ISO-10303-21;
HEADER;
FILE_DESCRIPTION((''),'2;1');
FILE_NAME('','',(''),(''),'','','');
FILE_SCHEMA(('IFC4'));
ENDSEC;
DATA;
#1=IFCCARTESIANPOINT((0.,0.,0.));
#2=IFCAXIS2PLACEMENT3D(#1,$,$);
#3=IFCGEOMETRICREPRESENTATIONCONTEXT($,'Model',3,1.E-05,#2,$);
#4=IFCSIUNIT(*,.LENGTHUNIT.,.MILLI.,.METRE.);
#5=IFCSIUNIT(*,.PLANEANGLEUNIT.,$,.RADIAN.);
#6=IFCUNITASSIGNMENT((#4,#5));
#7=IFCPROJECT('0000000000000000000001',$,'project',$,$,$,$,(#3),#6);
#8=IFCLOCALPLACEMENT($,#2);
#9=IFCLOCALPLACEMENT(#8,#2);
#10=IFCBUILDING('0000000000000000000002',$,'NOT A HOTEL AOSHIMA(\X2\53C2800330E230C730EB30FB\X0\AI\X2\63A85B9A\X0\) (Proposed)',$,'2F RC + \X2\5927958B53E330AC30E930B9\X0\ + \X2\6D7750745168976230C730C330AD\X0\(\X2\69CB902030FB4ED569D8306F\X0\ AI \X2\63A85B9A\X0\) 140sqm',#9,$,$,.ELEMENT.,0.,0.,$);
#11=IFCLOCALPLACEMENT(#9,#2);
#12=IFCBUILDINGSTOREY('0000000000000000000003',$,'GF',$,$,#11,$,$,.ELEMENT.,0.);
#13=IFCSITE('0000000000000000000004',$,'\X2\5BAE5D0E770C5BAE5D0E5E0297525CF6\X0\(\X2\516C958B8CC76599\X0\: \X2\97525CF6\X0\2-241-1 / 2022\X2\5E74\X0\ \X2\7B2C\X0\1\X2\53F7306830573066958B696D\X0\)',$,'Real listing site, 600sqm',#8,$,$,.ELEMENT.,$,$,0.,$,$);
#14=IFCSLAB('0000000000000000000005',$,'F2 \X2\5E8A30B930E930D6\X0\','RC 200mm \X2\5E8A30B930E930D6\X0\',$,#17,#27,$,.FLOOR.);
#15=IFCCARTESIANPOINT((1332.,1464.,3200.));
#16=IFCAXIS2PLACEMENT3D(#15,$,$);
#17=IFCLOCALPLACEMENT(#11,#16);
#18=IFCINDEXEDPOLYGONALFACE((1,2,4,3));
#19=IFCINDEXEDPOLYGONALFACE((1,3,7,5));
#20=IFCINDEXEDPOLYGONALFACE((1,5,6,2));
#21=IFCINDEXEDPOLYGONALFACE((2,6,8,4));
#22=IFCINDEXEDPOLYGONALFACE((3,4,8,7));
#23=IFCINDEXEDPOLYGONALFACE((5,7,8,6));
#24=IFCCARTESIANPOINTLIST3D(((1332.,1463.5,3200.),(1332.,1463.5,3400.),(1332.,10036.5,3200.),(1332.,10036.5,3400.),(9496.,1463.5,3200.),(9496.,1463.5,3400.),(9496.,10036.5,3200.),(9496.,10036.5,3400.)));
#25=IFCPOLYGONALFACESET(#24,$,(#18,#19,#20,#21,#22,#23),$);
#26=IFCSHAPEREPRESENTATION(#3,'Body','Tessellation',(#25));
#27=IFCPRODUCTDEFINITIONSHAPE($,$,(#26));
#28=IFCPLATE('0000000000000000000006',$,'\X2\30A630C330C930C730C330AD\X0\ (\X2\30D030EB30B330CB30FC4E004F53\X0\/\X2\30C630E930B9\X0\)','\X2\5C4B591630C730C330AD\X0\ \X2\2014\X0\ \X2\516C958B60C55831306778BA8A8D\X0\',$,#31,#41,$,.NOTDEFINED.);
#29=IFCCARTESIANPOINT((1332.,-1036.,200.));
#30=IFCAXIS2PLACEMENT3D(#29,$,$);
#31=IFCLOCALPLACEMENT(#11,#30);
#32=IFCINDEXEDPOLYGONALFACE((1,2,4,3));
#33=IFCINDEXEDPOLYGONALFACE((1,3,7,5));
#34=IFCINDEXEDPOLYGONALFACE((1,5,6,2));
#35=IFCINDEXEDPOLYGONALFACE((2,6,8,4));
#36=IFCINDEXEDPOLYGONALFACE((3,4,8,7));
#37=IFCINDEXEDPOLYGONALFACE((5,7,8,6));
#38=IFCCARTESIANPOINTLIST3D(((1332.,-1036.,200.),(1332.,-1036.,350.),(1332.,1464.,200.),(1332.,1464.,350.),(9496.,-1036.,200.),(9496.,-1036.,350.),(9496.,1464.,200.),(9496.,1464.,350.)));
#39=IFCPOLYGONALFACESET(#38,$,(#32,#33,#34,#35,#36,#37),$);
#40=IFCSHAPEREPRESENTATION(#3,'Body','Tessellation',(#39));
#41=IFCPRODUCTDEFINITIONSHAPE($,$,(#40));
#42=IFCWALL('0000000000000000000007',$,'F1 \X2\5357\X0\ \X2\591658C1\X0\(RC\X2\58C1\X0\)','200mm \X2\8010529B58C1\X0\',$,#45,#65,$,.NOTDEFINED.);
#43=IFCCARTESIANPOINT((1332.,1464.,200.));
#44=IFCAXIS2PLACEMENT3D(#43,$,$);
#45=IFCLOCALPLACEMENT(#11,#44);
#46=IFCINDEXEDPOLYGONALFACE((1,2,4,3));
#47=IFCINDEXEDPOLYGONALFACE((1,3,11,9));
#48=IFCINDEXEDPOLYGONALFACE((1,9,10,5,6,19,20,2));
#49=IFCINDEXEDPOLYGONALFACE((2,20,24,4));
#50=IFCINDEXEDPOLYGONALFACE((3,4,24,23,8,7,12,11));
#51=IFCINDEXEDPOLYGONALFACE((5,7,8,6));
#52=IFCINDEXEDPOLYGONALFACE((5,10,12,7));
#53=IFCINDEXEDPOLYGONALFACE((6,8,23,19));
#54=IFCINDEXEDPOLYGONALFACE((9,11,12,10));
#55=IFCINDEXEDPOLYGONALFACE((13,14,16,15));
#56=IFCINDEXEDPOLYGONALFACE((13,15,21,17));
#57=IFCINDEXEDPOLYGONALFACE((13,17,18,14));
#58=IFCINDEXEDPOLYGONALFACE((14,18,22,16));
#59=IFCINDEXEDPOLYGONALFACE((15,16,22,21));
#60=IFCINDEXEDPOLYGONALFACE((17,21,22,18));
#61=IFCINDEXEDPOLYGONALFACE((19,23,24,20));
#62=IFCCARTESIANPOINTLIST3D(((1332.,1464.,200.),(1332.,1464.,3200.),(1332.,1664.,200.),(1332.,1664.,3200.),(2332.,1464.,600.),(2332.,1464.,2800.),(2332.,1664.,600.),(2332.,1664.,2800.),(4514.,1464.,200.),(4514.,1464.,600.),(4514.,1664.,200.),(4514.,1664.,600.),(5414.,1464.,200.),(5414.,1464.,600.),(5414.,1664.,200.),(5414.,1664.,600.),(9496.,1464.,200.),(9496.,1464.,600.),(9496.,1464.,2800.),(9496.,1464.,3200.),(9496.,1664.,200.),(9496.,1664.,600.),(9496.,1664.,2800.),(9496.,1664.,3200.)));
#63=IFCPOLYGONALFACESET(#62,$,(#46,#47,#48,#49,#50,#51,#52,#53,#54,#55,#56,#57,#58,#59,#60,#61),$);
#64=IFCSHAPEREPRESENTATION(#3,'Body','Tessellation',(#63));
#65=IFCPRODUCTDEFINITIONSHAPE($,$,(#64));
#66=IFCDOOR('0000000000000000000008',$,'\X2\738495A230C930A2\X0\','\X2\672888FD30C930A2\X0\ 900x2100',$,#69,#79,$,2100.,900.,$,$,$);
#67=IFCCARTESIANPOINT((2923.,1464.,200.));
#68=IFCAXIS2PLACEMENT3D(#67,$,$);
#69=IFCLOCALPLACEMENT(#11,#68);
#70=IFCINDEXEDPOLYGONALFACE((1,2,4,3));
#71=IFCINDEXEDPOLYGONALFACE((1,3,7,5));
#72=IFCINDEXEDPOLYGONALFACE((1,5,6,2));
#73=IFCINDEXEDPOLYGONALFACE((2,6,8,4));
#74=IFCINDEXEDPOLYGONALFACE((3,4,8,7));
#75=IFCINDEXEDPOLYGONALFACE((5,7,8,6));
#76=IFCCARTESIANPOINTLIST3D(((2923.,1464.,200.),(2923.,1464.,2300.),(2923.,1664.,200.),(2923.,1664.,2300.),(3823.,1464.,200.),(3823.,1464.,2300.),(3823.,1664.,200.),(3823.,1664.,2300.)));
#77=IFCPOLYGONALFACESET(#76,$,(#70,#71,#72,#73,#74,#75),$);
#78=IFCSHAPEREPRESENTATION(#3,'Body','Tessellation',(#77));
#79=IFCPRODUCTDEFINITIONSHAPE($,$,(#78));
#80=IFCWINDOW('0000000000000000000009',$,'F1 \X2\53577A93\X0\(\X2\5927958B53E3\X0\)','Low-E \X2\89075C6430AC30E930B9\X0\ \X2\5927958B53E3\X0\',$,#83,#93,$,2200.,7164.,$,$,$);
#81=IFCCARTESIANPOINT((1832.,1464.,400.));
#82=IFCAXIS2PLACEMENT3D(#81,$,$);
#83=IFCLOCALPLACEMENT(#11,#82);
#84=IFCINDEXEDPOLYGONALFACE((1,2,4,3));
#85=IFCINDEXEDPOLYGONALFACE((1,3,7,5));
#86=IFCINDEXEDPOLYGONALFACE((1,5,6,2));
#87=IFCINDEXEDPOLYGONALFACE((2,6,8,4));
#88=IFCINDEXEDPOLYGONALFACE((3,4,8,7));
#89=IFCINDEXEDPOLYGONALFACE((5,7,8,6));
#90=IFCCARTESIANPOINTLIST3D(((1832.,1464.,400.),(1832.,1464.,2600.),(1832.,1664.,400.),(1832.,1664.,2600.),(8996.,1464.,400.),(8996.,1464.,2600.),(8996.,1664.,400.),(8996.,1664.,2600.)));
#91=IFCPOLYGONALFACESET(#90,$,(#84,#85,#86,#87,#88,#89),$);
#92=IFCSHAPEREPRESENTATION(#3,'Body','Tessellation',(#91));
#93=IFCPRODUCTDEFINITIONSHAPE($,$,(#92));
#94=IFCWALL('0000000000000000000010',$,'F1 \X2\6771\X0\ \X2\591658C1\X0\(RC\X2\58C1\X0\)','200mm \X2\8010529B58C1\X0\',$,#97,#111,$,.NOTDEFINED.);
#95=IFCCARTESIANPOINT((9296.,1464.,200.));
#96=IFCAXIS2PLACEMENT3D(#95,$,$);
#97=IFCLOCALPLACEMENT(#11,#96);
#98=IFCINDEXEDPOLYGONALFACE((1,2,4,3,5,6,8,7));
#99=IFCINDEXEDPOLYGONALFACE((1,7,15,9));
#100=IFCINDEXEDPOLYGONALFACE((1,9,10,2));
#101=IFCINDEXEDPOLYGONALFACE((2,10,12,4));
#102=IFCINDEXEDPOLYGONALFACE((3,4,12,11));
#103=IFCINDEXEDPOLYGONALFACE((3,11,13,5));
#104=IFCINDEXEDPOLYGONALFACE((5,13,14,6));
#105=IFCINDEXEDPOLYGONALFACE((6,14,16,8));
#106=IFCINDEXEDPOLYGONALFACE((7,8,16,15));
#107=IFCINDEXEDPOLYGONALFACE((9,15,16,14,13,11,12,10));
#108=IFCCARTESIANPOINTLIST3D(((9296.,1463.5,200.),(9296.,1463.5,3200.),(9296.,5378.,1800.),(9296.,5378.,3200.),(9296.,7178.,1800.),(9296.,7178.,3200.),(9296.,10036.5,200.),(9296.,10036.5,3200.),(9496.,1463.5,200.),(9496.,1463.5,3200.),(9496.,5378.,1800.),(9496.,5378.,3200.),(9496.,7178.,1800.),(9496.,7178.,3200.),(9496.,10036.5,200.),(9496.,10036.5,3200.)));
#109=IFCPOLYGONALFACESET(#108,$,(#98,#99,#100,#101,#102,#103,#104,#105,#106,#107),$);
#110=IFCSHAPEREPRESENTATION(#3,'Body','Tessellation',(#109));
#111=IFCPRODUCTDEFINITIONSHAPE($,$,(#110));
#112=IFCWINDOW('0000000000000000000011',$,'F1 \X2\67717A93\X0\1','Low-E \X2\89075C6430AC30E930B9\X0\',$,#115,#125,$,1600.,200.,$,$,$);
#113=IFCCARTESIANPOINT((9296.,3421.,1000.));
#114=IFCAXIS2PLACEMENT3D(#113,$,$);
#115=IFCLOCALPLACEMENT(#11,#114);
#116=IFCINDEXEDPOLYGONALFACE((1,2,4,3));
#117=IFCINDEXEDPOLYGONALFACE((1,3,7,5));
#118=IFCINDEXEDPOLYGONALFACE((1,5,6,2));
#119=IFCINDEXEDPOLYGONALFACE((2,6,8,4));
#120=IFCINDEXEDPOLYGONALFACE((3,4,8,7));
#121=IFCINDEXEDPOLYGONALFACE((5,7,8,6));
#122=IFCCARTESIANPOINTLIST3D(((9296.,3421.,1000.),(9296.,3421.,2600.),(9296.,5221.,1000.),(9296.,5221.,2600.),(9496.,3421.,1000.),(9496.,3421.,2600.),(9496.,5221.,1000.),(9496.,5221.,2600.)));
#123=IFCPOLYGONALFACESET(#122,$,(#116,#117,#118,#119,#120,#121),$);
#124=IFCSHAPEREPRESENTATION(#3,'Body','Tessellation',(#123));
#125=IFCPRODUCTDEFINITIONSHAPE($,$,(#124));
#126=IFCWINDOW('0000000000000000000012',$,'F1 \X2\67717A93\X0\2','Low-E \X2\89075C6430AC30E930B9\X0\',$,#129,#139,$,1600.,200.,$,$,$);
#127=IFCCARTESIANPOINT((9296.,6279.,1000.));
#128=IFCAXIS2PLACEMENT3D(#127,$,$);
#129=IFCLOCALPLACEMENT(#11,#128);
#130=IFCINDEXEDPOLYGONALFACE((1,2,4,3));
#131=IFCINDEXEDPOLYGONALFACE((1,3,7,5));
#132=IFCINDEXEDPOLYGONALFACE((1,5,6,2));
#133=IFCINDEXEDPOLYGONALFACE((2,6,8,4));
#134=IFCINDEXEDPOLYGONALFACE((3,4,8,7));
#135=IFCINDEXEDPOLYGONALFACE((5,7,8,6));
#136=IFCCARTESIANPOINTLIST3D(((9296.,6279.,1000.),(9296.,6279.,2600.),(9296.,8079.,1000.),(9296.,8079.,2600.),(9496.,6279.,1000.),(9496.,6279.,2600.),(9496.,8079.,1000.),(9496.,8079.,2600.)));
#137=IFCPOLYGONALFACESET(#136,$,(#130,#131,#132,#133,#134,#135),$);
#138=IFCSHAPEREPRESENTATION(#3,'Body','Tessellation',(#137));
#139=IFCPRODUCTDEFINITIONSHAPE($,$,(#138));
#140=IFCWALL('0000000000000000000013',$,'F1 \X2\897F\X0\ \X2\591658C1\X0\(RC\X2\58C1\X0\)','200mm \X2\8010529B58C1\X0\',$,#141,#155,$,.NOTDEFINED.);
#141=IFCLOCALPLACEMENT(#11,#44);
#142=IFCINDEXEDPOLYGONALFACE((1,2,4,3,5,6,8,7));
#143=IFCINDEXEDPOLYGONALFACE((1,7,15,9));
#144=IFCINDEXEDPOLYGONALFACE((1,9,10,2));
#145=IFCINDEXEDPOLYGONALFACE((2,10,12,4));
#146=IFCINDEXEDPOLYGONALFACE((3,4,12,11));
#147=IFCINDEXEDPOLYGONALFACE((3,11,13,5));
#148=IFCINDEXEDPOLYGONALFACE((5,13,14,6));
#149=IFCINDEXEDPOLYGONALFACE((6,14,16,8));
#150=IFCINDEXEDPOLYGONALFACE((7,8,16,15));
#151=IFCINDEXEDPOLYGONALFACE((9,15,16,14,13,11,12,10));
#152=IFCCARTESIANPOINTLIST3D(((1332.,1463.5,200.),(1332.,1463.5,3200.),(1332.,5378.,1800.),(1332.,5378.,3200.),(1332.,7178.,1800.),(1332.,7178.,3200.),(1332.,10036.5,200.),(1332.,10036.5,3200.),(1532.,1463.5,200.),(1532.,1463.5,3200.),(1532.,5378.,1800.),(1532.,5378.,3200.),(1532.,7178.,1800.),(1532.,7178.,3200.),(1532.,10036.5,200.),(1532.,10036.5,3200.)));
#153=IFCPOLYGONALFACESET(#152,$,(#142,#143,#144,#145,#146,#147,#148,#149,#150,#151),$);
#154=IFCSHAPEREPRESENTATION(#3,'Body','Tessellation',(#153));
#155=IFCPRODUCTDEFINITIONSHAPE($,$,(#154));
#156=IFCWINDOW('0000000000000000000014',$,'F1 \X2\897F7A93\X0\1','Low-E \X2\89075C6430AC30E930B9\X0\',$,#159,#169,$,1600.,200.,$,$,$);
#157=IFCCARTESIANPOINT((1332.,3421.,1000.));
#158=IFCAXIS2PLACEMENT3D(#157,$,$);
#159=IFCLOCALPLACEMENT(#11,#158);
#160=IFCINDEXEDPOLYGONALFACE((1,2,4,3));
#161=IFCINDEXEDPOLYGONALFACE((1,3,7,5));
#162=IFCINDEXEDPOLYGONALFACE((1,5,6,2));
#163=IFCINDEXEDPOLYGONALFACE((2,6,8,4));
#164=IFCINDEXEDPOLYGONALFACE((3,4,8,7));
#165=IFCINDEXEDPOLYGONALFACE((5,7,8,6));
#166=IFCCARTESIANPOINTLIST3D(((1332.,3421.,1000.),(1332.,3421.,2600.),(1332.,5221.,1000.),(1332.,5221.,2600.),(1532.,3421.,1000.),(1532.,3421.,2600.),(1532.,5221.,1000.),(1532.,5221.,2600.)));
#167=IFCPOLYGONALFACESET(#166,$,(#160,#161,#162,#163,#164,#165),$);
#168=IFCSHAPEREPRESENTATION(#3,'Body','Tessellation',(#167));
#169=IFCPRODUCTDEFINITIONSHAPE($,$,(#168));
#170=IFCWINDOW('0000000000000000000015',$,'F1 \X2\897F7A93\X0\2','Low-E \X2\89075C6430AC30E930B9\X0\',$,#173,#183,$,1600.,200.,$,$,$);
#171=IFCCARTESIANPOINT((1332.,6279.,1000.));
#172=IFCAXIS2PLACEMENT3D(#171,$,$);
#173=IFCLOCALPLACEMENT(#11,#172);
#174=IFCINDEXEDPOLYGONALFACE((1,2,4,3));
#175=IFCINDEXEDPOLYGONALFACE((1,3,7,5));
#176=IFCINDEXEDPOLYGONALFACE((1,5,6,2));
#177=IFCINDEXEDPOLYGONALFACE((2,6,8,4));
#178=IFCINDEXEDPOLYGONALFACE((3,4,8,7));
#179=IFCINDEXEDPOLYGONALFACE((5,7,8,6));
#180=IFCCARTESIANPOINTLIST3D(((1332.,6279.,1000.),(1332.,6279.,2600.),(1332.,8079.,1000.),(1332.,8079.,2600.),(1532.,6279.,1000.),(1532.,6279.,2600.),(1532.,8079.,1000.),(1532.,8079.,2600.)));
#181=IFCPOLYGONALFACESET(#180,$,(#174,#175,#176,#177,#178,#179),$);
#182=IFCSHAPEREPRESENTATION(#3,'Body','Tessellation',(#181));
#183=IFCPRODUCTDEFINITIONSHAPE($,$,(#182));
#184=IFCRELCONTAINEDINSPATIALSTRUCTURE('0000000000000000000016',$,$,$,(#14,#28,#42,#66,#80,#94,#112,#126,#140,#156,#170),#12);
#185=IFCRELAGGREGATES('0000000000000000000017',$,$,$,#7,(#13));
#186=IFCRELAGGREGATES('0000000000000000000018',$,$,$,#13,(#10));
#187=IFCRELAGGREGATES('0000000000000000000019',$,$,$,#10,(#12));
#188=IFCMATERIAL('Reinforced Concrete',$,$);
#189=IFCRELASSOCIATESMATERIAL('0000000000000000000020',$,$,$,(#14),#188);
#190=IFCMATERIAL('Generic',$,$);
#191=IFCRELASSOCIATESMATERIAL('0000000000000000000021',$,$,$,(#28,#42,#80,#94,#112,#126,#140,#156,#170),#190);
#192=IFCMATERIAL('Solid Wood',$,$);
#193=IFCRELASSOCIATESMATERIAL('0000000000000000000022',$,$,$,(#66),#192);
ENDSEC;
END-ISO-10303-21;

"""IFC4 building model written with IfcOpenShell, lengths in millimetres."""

from ifc_helpers import new_model, si_unit, frame, frame_2d, origin, place, context, project, spatial, rectangle, extrude, material, element, fill, save


model = new_model("IFC4")

# Units and contexts
model_context = context("Model", 3, precision=1e-05, world=origin())
ifc_project = project(units=[si_unit("LENGTHUNIT", "METRE", prefix="MILLI"), si_unit("PLANEANGLEUNIT", "RADIAN")], contexts=[model_context])

# Site, building, storey
site_placement = place(None, origin())
site = spatial("IfcSite", under=ifc_project, at=site_placement, Name="宮崎県宮崎市青島(公開資料: 青島2-241-1 / 2022年 第1号として開業)", ObjectType="Real listing site, 600sqm", CompositionType="ELEMENT", RefElevation=0.0)
building_placement = place(site_placement, origin())
building = spatial("IfcBuilding", under=site, at=building_placement, Name="NOT A HOTEL AOSHIMA(参考モデル・AI推定) (Proposed)", ObjectType="2F RC + 大開口ガラス + 海側全面デッキ(構造・仕様は AI 推定) 140sqm", CompositionType="ELEMENT", ElevationOfRefHeight=0.0, ElevationOfTerrain=0.0)
storey_placement = place(building_placement, origin())
storey = spatial("IfcBuildingStorey", under=building, at=storey_placement, Name="GF", CompositionType="ELEMENT", Elevation=0.0)

# Slab
ifc_material_1 = material(Name="Reinforced Concrete")
slab_1_placement = place(storey_placement, frame((1332.0, 1464.0, 3200.0)))
element("IfcSlab", 1, at=slab_1_placement, inside=storey, material=ifc_material_1, Name="F2 床スラブ", Description="RC 200mm 床スラブ", PredefinedType="FLOOR", context=model_context, shape_type="SweptSolid", body=[
    extrude(rectangle(XDim=8164.0, YDim=8573.0, at=frame_2d((4082.0, 4286.0))), frame((1332.0, 1464.0, 3200.0)), (0.0, 0.0, 1.0), 200.0),
])

# Plate
ifc_material_2 = material(Name="Generic")
plate_placement = place(storey_placement, frame((1332.0, -1036.0, 200.0)))
element("IfcPlate", 2, at=plate_placement, inside=storey, material=ifc_material_2, Name="ウッドデッキ (バルコニー一体/テラス)", Description="屋外デッキ — 公開情報で確認", PredefinedType="NOTDEFINED", context=model_context, shape_type="SweptSolid", body=[
    extrude(rectangle(XDim=8164.0, YDim=2500.0, at=frame_2d((4082.0, 1250.0))), frame((1332.0, -1036.0, 200.0)), (0.0, 0.0, 1.0), 150.0),
])

# Wall, openings, door, window
wall_1_placement = place(storey_placement, frame((1332.0, 1464.0, 200.0)))
wall_1 = element("IfcWall", 3, at=wall_1_placement, inside=storey, material=ifc_material_2, Name="F1 南 外壁(RC壁)", Description="200mm 耐力壁", PredefinedType="NOTDEFINED", context=model_context, shape_type="SweptSolid", body=[
    extrude(rectangle(XDim=8164.0, YDim=200.0, at=frame_2d((4082.0, 100.0))), frame((1332.0, 1464.0, 200.0)), (0.0, 0.0, 1.0), 3000.0),
])
opening_1_placement = place(storey_placement, frame((2923.0, 1464.0, 200.0)))
opening_1 = element("IfcOpeningElement", 4, at=opening_1_placement, cuts=wall_1, PredefinedType="NOTDEFINED", context=model_context, shape_type="SweptSolid", body=[
    extrude(rectangle(XDim=900.0, YDim=200.0, at=frame_2d((450.0, 100.0))), frame((2923.0, 1464.0, 200.0)), (0.0, 0.0, 1.0), 2100.0),
])
opening_2_placement = place(storey_placement, frame((1832.0, 1464.0, 400.0)))
opening_2 = element("IfcOpeningElement", 5, at=opening_2_placement, cuts=wall_1, PredefinedType="NOTDEFINED", context=model_context, shape_type="SweptSolid", body=[
    extrude(rectangle(XDim=7164.0, YDim=200.0, at=frame_2d((3582.0, 100.0))), frame((1832.0, 1464.0, 400.0)), (0.0, 0.0, 1.0), 2200.0),
])
ifc_material_3 = material(Name="Solid Wood")
door_placement = place(storey_placement, frame((2923.0, 1464.0, 200.0)))
door = element("IfcDoor", 6, at=door_placement, inside=storey, material=ifc_material_3, Name="玄関ドア", Description="木製ドア 900x2100", OverallHeight=2100.0, OverallWidth=900.0, context=model_context, shape_type="SweptSolid", body=[
    extrude(rectangle(XDim=900.0, YDim=200.0, at=frame_2d((450.0, 100.0))), frame((2923.0, 1464.0, 200.0)), (0.0, 0.0, 1.0), 2100.0),
])
fill(opening_1, door)
window_1_placement = place(storey_placement, frame((1832.0, 1464.0, 400.0)))
window_1 = element("IfcWindow", 7, at=window_1_placement, inside=storey, material=ifc_material_2, Name="F1 南窓(大開口)", Description="Low-E 複層ガラス 大開口", OverallHeight=2200.0, OverallWidth=7164.0, context=model_context, shape_type="SweptSolid", body=[
    extrude(rectangle(XDim=7164.0, YDim=200.0, at=frame_2d((3582.0, 100.0))), frame((1832.0, 1464.0, 400.0)), (0.0, 0.0, 1.0), 2200.0),
])
fill(opening_2, window_1)

# Walls, openings, windows
wall_2_placement = place(storey_placement, frame((9296.0, 1464.0, 200.0)))
wall_2 = element("IfcWall", 8, at=wall_2_placement, inside=storey, material=ifc_material_2, Name="F1 東 外壁(RC壁)", Description="200mm 耐力壁", PredefinedType="NOTDEFINED", context=model_context, shape_type="SweptSolid", body=[
    extrude(rectangle(XDim=200.0, YDim=8573.0, at=frame_2d((100.0, 4286.0))), frame((9296.0, 1464.0, 200.0)), (0.0, 0.0, 1.0), 3000.0),
])
opening_3_placement = place(storey_placement, frame((9296.0, 3421.0, 1000.0)))
opening_3 = element("IfcOpeningElement", 9, at=opening_3_placement, cuts=wall_2, PredefinedType="NOTDEFINED", context=model_context, shape_type="SweptSolid", body=[
    extrude(rectangle(XDim=200.0, YDim=1800.0, at=frame_2d((100.0, 900.0))), frame((9296.0, 3421.0, 1000.0)), (0.0, 0.0, 1.0), 1600.0),
])
opening_4_placement = place(storey_placement, frame((9296.0, 6279.0, 1000.0)))
opening_4 = element("IfcOpeningElement", 10, at=opening_4_placement, cuts=wall_2, PredefinedType="NOTDEFINED", context=model_context, shape_type="SweptSolid", body=[
    extrude(rectangle(XDim=200.0, YDim=1800.0, at=frame_2d((100.0, 900.0))), frame((9296.0, 6279.0, 1000.0)), (0.0, 0.0, 1.0), 1600.0),
])
window_2_placement = place(storey_placement, frame((9296.0, 3421.0, 1000.0)))
window_2 = element("IfcWindow", 11, at=window_2_placement, inside=storey, material=ifc_material_2, Name="F1 東窓1", Description="Low-E 複層ガラス", OverallHeight=1600.0, OverallWidth=200.0, context=model_context, shape_type="SweptSolid", body=[
    extrude(rectangle(XDim=200.0, YDim=1800.0, at=frame_2d((100.0, 900.0))), frame((9296.0, 3421.0, 1000.0)), (0.0, 0.0, 1.0), 1600.0),
])
fill(opening_3, window_2)
window_3_placement = place(storey_placement, frame((9296.0, 6279.0, 1000.0)))
window_3 = element("IfcWindow", 12, at=window_3_placement, inside=storey, material=ifc_material_2, Name="F1 東窓2", Description="Low-E 複層ガラス", OverallHeight=1600.0, OverallWidth=200.0, context=model_context, shape_type="SweptSolid", body=[
    extrude(rectangle(XDim=200.0, YDim=1800.0, at=frame_2d((100.0, 900.0))), frame((9296.0, 6279.0, 1000.0)), (0.0, 0.0, 1.0), 1600.0),
])
fill(opening_4, window_3)
wall_3_placement = place(storey_placement, frame((1332.0, 1464.0, 200.0)))
wall_3 = element("IfcWall", 13, at=wall_3_placement, inside=storey, material=ifc_material_2, Name="F1 西 外壁(RC壁)", Description="200mm 耐力壁", PredefinedType="NOTDEFINED", context=model_context, shape_type="SweptSolid", body=[
    extrude(rectangle(XDim=200.0, YDim=8573.0, at=frame_2d((100.0, 4286.0))), frame((1332.0, 1464.0, 200.0)), (0.0, 0.0, 1.0), 3000.0),
])
opening_5_placement = place(storey_placement, frame((1332.0, 3421.0, 1000.0)))
opening_5 = element("IfcOpeningElement", 14, at=opening_5_placement, cuts=wall_3, PredefinedType="NOTDEFINED", context=model_context, shape_type="SweptSolid", body=[
    extrude(rectangle(XDim=200.0, YDim=1800.0, at=frame_2d((100.0, 900.0))), frame((1332.0, 3421.0, 1000.0)), (0.0, 0.0, 1.0), 1600.0),
])
opening_6_placement = place(storey_placement, frame((1332.0, 6279.0, 1000.0)))
opening_6 = element("IfcOpeningElement", 15, at=opening_6_placement, cuts=wall_3, PredefinedType="NOTDEFINED", context=model_context, shape_type="SweptSolid", body=[
    extrude(rectangle(XDim=200.0, YDim=1800.0, at=frame_2d((100.0, 900.0))), frame((1332.0, 6279.0, 1000.0)), (0.0, 0.0, 1.0), 1600.0),
])
window_4_placement = place(storey_placement, frame((1332.0, 3421.0, 1000.0)))
window_4 = element("IfcWindow", 16, at=window_4_placement, inside=storey, material=ifc_material_2, Name="F1 西窓1", Description="Low-E 複層ガラス", OverallHeight=1600.0, OverallWidth=200.0, context=model_context, shape_type="SweptSolid", body=[
    extrude(rectangle(XDim=200.0, YDim=1800.0, at=frame_2d((100.0, 900.0))), frame((1332.0, 3421.0, 1000.0)), (0.0, 0.0, 1.0), 1600.0),
])
fill(opening_5, window_4)
window_5_placement = place(storey_placement, frame((1332.0, 6279.0, 1000.0)))
window_5 = element("IfcWindow", 17, at=window_5_placement, inside=storey, material=ifc_material_2, Name="F1 西窓2", Description="Low-E 複層ガラス", OverallHeight=1600.0, OverallWidth=200.0, context=model_context, shape_type="SweptSolid", body=[
    extrude(rectangle(XDim=200.0, YDim=1800.0, at=frame_2d((100.0, 900.0))), frame((1332.0, 6279.0, 1000.0)), (0.0, 0.0, 1.0), 1600.0),
])
fill(opening_6, window_5)

save(model, "model.ifc")
